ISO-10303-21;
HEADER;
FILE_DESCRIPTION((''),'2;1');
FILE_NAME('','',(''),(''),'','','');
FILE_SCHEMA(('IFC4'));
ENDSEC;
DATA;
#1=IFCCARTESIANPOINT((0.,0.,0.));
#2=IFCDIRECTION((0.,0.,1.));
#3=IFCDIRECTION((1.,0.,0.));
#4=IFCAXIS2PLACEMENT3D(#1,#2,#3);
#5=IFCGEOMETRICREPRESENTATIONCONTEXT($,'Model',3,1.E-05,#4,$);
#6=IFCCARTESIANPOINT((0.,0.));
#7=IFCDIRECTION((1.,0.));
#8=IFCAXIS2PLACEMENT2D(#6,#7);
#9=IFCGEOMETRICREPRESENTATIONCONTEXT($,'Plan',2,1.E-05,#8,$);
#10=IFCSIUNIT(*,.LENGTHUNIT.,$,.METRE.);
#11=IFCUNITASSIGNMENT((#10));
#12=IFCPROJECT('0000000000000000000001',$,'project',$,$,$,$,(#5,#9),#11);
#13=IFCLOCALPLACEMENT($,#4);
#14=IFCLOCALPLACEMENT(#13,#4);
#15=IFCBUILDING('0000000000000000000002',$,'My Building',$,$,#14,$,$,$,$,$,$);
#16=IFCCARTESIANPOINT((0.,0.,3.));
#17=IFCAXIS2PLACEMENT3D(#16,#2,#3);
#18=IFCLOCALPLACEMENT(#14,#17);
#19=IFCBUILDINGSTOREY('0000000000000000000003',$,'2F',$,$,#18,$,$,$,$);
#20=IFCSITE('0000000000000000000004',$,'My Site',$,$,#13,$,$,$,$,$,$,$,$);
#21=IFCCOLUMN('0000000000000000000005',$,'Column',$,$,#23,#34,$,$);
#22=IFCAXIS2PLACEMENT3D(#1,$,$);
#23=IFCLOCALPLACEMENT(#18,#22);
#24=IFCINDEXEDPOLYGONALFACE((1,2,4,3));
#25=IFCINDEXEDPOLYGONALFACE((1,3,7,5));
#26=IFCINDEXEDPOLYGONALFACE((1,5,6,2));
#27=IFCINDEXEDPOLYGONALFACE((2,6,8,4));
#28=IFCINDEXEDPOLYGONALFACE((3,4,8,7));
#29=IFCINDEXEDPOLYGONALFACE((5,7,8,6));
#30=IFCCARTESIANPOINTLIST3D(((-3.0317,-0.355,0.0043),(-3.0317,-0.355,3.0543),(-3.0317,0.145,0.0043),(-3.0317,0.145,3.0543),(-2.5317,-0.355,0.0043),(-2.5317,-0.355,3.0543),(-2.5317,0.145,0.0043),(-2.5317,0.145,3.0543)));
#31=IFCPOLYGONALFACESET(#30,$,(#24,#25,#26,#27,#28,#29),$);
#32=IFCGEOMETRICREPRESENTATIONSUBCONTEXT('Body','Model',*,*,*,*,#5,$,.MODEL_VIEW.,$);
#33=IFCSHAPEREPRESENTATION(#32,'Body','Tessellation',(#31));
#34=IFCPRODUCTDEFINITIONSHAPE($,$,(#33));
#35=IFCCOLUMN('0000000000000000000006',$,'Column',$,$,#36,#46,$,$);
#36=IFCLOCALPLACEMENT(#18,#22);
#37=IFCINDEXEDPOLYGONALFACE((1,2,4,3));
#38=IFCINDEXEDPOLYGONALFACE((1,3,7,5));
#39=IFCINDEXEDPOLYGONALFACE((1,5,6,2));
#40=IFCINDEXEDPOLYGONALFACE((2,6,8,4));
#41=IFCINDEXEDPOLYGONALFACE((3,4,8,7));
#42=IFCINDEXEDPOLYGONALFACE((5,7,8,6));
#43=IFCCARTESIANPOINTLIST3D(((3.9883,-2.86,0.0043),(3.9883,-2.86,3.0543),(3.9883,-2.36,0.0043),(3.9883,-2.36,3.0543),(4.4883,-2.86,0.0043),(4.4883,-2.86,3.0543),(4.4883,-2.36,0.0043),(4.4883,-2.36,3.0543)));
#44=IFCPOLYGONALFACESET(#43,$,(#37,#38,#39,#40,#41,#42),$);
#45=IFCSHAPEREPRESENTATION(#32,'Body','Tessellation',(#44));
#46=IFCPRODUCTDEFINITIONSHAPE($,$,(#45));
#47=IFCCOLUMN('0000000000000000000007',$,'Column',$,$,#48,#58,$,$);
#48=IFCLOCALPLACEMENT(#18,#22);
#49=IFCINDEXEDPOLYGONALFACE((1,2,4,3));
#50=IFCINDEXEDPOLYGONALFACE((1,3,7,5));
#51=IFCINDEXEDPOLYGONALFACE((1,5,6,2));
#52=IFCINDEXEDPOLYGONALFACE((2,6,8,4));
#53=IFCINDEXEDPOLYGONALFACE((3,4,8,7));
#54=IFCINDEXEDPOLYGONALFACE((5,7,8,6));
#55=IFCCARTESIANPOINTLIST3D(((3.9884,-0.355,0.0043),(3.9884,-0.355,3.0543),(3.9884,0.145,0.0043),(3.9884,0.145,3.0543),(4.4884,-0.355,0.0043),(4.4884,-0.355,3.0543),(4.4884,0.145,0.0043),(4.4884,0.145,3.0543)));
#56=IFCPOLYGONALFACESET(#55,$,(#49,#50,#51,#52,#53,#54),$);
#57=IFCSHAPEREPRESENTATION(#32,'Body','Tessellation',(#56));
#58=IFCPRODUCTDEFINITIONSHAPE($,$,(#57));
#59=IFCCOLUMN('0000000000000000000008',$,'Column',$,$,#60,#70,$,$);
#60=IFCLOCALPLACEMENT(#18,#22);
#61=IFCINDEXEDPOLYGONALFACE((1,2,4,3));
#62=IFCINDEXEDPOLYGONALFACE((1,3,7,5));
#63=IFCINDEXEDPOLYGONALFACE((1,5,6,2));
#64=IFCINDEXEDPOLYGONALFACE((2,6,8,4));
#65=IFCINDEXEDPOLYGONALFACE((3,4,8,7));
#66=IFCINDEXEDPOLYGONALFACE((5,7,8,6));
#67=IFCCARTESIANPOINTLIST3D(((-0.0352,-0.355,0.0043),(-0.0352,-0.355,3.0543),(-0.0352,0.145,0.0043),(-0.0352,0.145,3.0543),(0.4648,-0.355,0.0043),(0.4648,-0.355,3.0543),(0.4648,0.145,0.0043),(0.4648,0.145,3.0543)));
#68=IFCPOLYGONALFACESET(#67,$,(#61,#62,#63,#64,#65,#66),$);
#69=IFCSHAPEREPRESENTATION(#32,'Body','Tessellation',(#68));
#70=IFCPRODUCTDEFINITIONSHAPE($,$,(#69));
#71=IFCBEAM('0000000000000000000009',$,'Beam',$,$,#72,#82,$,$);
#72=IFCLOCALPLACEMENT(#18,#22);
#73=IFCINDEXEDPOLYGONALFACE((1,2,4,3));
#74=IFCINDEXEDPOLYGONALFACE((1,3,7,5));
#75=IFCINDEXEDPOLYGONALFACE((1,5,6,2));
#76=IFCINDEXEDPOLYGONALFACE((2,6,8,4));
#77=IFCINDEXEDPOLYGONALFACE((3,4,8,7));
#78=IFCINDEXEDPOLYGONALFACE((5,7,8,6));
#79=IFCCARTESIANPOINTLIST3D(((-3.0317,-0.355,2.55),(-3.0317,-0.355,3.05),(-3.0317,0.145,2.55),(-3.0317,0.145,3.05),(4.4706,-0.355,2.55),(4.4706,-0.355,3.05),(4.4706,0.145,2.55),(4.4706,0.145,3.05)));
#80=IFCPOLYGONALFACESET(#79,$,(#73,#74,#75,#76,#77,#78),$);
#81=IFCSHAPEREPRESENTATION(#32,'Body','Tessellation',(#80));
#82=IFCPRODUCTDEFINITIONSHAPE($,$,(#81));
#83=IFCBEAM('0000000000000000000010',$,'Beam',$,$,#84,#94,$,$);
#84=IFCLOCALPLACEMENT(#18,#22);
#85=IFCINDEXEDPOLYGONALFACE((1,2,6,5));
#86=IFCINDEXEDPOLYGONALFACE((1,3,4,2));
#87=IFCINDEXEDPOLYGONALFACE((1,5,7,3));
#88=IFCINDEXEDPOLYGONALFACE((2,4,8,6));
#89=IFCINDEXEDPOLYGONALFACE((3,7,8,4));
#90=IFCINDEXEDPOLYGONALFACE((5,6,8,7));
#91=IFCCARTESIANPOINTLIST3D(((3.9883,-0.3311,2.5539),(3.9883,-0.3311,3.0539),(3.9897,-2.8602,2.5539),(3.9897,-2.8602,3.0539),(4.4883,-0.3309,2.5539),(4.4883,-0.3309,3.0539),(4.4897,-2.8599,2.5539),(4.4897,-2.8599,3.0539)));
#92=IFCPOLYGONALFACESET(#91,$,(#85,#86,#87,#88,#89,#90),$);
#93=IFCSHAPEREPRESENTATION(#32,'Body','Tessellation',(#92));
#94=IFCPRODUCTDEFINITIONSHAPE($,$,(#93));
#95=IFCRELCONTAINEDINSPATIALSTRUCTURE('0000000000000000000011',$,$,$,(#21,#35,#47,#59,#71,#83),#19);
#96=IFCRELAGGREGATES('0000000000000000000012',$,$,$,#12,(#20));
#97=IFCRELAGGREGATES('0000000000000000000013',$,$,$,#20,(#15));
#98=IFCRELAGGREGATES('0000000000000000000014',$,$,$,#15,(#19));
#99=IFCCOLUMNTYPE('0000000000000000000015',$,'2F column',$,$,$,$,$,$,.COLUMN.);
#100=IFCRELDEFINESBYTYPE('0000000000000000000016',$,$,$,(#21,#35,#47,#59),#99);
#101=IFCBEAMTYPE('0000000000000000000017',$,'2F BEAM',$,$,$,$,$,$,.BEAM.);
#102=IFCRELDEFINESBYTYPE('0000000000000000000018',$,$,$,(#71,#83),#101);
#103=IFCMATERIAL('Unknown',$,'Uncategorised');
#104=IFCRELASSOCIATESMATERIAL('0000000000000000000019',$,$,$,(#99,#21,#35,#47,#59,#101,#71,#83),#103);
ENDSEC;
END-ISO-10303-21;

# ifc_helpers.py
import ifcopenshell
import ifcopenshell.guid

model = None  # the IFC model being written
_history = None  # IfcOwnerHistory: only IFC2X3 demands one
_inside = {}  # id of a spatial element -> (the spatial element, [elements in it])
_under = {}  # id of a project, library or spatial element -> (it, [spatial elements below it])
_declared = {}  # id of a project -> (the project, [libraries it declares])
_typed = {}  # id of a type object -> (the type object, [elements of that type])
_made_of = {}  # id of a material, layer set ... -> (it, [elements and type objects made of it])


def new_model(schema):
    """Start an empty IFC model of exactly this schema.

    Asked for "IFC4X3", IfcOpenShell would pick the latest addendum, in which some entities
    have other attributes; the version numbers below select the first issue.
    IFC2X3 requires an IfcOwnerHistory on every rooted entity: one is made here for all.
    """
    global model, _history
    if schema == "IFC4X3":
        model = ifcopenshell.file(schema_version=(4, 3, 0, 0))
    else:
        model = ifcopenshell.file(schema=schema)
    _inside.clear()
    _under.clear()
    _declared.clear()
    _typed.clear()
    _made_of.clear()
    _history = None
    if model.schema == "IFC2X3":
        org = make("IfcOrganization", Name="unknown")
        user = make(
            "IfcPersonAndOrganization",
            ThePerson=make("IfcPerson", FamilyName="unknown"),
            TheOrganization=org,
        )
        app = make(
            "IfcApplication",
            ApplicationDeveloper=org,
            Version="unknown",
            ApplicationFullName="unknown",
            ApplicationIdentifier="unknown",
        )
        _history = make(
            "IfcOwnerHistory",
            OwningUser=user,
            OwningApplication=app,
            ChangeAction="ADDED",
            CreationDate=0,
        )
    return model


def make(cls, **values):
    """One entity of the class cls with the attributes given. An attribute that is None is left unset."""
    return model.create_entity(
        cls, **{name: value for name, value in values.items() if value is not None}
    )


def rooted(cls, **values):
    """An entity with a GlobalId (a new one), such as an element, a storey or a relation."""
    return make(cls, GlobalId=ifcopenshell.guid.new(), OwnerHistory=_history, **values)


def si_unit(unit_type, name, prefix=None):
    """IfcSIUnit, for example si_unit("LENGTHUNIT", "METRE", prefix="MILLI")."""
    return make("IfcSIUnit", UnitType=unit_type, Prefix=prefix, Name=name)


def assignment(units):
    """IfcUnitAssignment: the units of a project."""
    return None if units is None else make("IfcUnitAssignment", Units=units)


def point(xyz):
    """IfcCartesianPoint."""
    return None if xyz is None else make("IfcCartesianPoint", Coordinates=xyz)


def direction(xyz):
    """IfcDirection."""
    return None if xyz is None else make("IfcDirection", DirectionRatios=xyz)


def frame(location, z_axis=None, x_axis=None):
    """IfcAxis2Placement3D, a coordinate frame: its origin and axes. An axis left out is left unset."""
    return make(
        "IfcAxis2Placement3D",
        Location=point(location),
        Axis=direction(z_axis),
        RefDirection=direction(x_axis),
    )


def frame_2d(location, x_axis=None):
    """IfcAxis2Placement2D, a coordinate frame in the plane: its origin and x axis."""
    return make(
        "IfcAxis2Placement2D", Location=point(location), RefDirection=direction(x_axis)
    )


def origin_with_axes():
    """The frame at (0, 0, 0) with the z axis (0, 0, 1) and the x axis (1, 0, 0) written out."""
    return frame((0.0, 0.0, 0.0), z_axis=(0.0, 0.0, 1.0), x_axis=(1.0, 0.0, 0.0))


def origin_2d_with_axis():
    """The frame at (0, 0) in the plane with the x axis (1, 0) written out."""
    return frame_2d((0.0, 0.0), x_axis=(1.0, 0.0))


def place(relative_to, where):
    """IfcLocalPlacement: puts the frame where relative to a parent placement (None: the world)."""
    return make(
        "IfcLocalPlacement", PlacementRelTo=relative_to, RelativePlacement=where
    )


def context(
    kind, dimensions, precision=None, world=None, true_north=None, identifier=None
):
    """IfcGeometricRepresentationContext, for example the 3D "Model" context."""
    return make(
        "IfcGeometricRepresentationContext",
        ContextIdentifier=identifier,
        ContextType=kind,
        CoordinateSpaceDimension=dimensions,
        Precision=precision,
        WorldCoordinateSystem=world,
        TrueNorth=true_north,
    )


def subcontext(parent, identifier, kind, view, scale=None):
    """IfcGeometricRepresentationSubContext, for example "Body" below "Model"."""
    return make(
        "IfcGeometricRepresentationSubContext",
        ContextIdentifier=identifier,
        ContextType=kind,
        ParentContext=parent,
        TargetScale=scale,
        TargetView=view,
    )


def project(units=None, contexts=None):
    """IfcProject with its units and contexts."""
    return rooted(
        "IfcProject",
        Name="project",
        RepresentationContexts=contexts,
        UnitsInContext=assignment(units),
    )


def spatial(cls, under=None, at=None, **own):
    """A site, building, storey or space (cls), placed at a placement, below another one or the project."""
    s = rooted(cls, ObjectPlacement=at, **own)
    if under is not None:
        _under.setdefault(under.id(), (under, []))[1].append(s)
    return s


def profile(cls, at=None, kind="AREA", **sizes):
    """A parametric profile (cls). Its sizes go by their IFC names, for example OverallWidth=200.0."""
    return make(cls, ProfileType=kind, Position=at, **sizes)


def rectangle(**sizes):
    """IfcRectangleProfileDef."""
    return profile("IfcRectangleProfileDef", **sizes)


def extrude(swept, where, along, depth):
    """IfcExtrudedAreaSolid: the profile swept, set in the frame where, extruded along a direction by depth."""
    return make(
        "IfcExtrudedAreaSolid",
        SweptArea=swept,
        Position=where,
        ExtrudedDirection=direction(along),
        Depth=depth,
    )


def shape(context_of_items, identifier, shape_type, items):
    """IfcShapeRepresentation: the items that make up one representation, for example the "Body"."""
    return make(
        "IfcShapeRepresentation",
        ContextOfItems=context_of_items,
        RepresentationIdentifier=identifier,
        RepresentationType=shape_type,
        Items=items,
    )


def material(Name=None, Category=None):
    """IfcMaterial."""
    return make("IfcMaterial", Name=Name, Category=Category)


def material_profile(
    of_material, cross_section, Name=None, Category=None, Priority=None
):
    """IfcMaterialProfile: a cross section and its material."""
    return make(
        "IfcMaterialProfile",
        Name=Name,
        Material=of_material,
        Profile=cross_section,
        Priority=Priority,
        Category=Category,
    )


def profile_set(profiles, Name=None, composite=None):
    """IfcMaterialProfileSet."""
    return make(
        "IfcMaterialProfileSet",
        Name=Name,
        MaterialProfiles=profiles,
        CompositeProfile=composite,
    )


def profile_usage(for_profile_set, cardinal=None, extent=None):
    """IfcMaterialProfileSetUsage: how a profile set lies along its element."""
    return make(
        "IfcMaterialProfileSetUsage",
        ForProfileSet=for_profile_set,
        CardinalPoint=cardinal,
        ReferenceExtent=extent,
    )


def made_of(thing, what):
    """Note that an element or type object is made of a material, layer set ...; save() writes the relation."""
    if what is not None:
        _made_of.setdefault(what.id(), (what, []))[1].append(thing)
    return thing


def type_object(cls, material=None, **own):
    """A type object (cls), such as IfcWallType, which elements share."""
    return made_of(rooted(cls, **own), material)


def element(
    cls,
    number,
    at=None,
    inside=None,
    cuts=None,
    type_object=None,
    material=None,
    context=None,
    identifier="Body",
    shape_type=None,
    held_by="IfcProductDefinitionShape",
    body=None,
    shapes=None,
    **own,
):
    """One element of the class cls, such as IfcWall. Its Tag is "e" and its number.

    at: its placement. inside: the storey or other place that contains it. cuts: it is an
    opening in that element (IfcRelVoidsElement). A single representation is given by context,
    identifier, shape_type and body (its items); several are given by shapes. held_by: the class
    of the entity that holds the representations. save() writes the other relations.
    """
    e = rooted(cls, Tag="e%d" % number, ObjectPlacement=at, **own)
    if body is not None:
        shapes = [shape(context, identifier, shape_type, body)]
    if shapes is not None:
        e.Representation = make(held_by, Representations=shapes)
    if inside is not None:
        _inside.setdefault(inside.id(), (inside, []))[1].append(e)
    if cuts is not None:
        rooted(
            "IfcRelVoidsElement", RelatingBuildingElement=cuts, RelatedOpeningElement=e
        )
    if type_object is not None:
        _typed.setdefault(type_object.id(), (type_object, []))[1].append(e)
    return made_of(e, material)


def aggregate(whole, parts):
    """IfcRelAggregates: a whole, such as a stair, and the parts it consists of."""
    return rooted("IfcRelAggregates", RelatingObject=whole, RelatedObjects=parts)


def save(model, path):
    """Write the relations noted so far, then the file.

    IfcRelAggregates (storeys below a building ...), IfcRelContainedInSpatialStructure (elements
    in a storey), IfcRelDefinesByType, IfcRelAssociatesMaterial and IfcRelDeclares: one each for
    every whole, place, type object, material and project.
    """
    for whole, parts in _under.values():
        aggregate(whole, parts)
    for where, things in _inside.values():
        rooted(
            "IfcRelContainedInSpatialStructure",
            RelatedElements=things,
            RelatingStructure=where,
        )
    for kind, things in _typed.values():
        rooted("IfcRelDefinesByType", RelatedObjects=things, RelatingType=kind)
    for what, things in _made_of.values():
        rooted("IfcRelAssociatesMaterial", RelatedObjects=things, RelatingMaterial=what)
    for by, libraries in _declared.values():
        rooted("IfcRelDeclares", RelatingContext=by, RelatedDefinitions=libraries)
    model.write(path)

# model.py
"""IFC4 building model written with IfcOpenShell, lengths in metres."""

from ifc_helpers import new_model, si_unit, frame, origin_with_axes, origin_2d_with_axis, place, context, subcontext, project, spatial, rectangle, extrude, material, material_profile, profile_set, profile_usage, type_object, element, save


model = new_model("IFC4")

# Units and contexts
model_context = context("Model", 3, precision=1e-05, world=origin_with_axes())
plan_context = context("Plan", 2, precision=1e-05, world=origin_2d_with_axis())
body_context_1 = subcontext(model_context, "Body", "Model", "MODEL_VIEW")
ifc_project = project(units=[si_unit("LENGTHUNIT", "METRE")], contexts=[model_context, plan_context])

# Site, building, storey
site_placement = place(None, origin_with_axes())
site = spatial("IfcSite", under=ifc_project, at=site_placement, Name="My Site")
building_placement = place(site_placement, origin_with_axes())
building = spatial("IfcBuilding", under=site, at=building_placement, Name="My Building")
storey_placement = place(building_placement, frame((0.0, 0.0, 3.0), z_axis=(0.0, 0.0, 1.0), x_axis=(1.0, 0.0, 0.0)))
storey = spatial("IfcBuildingStorey", under=building, at=storey_placement, Name="2F")

# Columns
ifc_material = material(Name="Unknown", Category="Uncategorised")
ifc_material_profile_1 = material_profile(ifc_material, rectangle(XDim=0.5, YDim=0.5))
ifc_profile_set_1 = profile_set([ifc_material_profile_1])
ifc_profile_usage_1 = profile_usage(ifc_profile_set_1, cardinal=5)
column_type = type_object("IfcColumnType", Name="2F column", PredefinedType="COLUMN", material=ifc_profile_set_1)
column_1_placement = place(storey_placement, frame((-2.7817, -0.105, 0.0043), z_axis=(0.0, 0.0, 1.0), x_axis=(1.0, 0.0, 0.0)))
element("IfcColumn", 1, at=column_1_placement, inside=storey, type_object=column_type, material=ifc_profile_usage_1, Name="Column", context=body_context_1, shape_type="SweptSolid", body=[
    extrude(rectangle(XDim=0.5, YDim=0.5), origin_with_axes(), (0.0, 0.0, 1.0), 3.05),
])
ifc_profile_usage_2 = profile_usage(ifc_profile_set_1, cardinal=5)
column_2_placement = place(storey_placement, frame((4.2383, -2.61, 0.0043), z_axis=(0.0, 0.0, 1.0), x_axis=(1.0, 0.0, 0.0)))
element("IfcColumn", 2, at=column_2_placement, inside=storey, type_object=column_type, material=ifc_profile_usage_2, Name="Column", context=body_context_1, shape_type="SweptSolid", body=[
    extrude(rectangle(XDim=0.5, YDim=0.5), origin_with_axes(), (0.0, 0.0, 1.0), 3.05),
])
ifc_profile_usage_3 = profile_usage(ifc_profile_set_1, cardinal=5)
column_3_placement = place(storey_placement, frame((4.2384, -0.105, 0.0043), z_axis=(0.0, 0.0, 1.0), x_axis=(1.0, 0.0, 0.0)))
element("IfcColumn", 3, at=column_3_placement, inside=storey, type_object=column_type, material=ifc_profile_usage_3, Name="Column", context=body_context_1, shape_type="SweptSolid", body=[
    extrude(rectangle(XDim=0.5, YDim=0.5), origin_with_axes(), (0.0, 0.0, 1.0), 3.05),
])
ifc_profile_usage_4 = profile_usage(ifc_profile_set_1, cardinal=5)
column_4_placement = place(storey_placement, frame((0.2148, -0.105, 0.0043), z_axis=(0.0, 0.0, 1.0), x_axis=(1.0, 0.0, 0.0)))
element("IfcColumn", 4, at=column_4_placement, inside=storey, type_object=column_type, material=ifc_profile_usage_4, Name="Column", context=body_context_1, shape_type="SweptSolid", body=[
    extrude(rectangle(XDim=0.5, YDim=0.5), origin_with_axes(), (0.0, 0.0, 1.0), 3.05),
])

# Beams
ifc_material_profile_2 = material_profile(ifc_material, rectangle(XDim=0.5, YDim=0.5))
ifc_profile_set_2 = profile_set([ifc_material_profile_2])
ifc_profile_usage_5 = profile_usage(ifc_profile_set_2, cardinal=5)
beam_type = type_object("IfcBeamType", Name="2F BEAM", PredefinedType="BEAM", material=ifc_profile_set_2)
beam_1_placement = place(storey_placement, frame((-3.0317, -0.105, 2.8), z_axis=(1.0, 0.0, 0.0), x_axis=(0.0, 1.0, 0.0)))
element("IfcBeam", 5, at=beam_1_placement, inside=storey, type_object=beam_type, material=ifc_profile_usage_5, Name="Beam", context=body_context_1, shape_type="SweptSolid", body=[
    extrude(rectangle(XDim=0.5, YDim=0.5), origin_with_axes(), (0.0, 0.0, 1.0), 7.5023),
])
ifc_profile_usage_6 = profile_usage(ifc_profile_set_2, cardinal=5)
beam_2_placement = place(storey_placement, frame((4.2383, -0.331, 2.8039), z_axis=(0.000534, -1.0, 0.0), x_axis=(1.0, 0.000534, 0.0)))
element("IfcBeam", 6, at=beam_2_placement, inside=storey, type_object=beam_type, material=ifc_profile_usage_6, Name="Beam", context=body_context_1, shape_type="SweptSolid", body=[
    extrude(rectangle(XDim=0.5, YDim=0.5), origin_with_axes(), (0.0, 0.0, 1.0), 2.529),
])

save(model, "model.ifc")
